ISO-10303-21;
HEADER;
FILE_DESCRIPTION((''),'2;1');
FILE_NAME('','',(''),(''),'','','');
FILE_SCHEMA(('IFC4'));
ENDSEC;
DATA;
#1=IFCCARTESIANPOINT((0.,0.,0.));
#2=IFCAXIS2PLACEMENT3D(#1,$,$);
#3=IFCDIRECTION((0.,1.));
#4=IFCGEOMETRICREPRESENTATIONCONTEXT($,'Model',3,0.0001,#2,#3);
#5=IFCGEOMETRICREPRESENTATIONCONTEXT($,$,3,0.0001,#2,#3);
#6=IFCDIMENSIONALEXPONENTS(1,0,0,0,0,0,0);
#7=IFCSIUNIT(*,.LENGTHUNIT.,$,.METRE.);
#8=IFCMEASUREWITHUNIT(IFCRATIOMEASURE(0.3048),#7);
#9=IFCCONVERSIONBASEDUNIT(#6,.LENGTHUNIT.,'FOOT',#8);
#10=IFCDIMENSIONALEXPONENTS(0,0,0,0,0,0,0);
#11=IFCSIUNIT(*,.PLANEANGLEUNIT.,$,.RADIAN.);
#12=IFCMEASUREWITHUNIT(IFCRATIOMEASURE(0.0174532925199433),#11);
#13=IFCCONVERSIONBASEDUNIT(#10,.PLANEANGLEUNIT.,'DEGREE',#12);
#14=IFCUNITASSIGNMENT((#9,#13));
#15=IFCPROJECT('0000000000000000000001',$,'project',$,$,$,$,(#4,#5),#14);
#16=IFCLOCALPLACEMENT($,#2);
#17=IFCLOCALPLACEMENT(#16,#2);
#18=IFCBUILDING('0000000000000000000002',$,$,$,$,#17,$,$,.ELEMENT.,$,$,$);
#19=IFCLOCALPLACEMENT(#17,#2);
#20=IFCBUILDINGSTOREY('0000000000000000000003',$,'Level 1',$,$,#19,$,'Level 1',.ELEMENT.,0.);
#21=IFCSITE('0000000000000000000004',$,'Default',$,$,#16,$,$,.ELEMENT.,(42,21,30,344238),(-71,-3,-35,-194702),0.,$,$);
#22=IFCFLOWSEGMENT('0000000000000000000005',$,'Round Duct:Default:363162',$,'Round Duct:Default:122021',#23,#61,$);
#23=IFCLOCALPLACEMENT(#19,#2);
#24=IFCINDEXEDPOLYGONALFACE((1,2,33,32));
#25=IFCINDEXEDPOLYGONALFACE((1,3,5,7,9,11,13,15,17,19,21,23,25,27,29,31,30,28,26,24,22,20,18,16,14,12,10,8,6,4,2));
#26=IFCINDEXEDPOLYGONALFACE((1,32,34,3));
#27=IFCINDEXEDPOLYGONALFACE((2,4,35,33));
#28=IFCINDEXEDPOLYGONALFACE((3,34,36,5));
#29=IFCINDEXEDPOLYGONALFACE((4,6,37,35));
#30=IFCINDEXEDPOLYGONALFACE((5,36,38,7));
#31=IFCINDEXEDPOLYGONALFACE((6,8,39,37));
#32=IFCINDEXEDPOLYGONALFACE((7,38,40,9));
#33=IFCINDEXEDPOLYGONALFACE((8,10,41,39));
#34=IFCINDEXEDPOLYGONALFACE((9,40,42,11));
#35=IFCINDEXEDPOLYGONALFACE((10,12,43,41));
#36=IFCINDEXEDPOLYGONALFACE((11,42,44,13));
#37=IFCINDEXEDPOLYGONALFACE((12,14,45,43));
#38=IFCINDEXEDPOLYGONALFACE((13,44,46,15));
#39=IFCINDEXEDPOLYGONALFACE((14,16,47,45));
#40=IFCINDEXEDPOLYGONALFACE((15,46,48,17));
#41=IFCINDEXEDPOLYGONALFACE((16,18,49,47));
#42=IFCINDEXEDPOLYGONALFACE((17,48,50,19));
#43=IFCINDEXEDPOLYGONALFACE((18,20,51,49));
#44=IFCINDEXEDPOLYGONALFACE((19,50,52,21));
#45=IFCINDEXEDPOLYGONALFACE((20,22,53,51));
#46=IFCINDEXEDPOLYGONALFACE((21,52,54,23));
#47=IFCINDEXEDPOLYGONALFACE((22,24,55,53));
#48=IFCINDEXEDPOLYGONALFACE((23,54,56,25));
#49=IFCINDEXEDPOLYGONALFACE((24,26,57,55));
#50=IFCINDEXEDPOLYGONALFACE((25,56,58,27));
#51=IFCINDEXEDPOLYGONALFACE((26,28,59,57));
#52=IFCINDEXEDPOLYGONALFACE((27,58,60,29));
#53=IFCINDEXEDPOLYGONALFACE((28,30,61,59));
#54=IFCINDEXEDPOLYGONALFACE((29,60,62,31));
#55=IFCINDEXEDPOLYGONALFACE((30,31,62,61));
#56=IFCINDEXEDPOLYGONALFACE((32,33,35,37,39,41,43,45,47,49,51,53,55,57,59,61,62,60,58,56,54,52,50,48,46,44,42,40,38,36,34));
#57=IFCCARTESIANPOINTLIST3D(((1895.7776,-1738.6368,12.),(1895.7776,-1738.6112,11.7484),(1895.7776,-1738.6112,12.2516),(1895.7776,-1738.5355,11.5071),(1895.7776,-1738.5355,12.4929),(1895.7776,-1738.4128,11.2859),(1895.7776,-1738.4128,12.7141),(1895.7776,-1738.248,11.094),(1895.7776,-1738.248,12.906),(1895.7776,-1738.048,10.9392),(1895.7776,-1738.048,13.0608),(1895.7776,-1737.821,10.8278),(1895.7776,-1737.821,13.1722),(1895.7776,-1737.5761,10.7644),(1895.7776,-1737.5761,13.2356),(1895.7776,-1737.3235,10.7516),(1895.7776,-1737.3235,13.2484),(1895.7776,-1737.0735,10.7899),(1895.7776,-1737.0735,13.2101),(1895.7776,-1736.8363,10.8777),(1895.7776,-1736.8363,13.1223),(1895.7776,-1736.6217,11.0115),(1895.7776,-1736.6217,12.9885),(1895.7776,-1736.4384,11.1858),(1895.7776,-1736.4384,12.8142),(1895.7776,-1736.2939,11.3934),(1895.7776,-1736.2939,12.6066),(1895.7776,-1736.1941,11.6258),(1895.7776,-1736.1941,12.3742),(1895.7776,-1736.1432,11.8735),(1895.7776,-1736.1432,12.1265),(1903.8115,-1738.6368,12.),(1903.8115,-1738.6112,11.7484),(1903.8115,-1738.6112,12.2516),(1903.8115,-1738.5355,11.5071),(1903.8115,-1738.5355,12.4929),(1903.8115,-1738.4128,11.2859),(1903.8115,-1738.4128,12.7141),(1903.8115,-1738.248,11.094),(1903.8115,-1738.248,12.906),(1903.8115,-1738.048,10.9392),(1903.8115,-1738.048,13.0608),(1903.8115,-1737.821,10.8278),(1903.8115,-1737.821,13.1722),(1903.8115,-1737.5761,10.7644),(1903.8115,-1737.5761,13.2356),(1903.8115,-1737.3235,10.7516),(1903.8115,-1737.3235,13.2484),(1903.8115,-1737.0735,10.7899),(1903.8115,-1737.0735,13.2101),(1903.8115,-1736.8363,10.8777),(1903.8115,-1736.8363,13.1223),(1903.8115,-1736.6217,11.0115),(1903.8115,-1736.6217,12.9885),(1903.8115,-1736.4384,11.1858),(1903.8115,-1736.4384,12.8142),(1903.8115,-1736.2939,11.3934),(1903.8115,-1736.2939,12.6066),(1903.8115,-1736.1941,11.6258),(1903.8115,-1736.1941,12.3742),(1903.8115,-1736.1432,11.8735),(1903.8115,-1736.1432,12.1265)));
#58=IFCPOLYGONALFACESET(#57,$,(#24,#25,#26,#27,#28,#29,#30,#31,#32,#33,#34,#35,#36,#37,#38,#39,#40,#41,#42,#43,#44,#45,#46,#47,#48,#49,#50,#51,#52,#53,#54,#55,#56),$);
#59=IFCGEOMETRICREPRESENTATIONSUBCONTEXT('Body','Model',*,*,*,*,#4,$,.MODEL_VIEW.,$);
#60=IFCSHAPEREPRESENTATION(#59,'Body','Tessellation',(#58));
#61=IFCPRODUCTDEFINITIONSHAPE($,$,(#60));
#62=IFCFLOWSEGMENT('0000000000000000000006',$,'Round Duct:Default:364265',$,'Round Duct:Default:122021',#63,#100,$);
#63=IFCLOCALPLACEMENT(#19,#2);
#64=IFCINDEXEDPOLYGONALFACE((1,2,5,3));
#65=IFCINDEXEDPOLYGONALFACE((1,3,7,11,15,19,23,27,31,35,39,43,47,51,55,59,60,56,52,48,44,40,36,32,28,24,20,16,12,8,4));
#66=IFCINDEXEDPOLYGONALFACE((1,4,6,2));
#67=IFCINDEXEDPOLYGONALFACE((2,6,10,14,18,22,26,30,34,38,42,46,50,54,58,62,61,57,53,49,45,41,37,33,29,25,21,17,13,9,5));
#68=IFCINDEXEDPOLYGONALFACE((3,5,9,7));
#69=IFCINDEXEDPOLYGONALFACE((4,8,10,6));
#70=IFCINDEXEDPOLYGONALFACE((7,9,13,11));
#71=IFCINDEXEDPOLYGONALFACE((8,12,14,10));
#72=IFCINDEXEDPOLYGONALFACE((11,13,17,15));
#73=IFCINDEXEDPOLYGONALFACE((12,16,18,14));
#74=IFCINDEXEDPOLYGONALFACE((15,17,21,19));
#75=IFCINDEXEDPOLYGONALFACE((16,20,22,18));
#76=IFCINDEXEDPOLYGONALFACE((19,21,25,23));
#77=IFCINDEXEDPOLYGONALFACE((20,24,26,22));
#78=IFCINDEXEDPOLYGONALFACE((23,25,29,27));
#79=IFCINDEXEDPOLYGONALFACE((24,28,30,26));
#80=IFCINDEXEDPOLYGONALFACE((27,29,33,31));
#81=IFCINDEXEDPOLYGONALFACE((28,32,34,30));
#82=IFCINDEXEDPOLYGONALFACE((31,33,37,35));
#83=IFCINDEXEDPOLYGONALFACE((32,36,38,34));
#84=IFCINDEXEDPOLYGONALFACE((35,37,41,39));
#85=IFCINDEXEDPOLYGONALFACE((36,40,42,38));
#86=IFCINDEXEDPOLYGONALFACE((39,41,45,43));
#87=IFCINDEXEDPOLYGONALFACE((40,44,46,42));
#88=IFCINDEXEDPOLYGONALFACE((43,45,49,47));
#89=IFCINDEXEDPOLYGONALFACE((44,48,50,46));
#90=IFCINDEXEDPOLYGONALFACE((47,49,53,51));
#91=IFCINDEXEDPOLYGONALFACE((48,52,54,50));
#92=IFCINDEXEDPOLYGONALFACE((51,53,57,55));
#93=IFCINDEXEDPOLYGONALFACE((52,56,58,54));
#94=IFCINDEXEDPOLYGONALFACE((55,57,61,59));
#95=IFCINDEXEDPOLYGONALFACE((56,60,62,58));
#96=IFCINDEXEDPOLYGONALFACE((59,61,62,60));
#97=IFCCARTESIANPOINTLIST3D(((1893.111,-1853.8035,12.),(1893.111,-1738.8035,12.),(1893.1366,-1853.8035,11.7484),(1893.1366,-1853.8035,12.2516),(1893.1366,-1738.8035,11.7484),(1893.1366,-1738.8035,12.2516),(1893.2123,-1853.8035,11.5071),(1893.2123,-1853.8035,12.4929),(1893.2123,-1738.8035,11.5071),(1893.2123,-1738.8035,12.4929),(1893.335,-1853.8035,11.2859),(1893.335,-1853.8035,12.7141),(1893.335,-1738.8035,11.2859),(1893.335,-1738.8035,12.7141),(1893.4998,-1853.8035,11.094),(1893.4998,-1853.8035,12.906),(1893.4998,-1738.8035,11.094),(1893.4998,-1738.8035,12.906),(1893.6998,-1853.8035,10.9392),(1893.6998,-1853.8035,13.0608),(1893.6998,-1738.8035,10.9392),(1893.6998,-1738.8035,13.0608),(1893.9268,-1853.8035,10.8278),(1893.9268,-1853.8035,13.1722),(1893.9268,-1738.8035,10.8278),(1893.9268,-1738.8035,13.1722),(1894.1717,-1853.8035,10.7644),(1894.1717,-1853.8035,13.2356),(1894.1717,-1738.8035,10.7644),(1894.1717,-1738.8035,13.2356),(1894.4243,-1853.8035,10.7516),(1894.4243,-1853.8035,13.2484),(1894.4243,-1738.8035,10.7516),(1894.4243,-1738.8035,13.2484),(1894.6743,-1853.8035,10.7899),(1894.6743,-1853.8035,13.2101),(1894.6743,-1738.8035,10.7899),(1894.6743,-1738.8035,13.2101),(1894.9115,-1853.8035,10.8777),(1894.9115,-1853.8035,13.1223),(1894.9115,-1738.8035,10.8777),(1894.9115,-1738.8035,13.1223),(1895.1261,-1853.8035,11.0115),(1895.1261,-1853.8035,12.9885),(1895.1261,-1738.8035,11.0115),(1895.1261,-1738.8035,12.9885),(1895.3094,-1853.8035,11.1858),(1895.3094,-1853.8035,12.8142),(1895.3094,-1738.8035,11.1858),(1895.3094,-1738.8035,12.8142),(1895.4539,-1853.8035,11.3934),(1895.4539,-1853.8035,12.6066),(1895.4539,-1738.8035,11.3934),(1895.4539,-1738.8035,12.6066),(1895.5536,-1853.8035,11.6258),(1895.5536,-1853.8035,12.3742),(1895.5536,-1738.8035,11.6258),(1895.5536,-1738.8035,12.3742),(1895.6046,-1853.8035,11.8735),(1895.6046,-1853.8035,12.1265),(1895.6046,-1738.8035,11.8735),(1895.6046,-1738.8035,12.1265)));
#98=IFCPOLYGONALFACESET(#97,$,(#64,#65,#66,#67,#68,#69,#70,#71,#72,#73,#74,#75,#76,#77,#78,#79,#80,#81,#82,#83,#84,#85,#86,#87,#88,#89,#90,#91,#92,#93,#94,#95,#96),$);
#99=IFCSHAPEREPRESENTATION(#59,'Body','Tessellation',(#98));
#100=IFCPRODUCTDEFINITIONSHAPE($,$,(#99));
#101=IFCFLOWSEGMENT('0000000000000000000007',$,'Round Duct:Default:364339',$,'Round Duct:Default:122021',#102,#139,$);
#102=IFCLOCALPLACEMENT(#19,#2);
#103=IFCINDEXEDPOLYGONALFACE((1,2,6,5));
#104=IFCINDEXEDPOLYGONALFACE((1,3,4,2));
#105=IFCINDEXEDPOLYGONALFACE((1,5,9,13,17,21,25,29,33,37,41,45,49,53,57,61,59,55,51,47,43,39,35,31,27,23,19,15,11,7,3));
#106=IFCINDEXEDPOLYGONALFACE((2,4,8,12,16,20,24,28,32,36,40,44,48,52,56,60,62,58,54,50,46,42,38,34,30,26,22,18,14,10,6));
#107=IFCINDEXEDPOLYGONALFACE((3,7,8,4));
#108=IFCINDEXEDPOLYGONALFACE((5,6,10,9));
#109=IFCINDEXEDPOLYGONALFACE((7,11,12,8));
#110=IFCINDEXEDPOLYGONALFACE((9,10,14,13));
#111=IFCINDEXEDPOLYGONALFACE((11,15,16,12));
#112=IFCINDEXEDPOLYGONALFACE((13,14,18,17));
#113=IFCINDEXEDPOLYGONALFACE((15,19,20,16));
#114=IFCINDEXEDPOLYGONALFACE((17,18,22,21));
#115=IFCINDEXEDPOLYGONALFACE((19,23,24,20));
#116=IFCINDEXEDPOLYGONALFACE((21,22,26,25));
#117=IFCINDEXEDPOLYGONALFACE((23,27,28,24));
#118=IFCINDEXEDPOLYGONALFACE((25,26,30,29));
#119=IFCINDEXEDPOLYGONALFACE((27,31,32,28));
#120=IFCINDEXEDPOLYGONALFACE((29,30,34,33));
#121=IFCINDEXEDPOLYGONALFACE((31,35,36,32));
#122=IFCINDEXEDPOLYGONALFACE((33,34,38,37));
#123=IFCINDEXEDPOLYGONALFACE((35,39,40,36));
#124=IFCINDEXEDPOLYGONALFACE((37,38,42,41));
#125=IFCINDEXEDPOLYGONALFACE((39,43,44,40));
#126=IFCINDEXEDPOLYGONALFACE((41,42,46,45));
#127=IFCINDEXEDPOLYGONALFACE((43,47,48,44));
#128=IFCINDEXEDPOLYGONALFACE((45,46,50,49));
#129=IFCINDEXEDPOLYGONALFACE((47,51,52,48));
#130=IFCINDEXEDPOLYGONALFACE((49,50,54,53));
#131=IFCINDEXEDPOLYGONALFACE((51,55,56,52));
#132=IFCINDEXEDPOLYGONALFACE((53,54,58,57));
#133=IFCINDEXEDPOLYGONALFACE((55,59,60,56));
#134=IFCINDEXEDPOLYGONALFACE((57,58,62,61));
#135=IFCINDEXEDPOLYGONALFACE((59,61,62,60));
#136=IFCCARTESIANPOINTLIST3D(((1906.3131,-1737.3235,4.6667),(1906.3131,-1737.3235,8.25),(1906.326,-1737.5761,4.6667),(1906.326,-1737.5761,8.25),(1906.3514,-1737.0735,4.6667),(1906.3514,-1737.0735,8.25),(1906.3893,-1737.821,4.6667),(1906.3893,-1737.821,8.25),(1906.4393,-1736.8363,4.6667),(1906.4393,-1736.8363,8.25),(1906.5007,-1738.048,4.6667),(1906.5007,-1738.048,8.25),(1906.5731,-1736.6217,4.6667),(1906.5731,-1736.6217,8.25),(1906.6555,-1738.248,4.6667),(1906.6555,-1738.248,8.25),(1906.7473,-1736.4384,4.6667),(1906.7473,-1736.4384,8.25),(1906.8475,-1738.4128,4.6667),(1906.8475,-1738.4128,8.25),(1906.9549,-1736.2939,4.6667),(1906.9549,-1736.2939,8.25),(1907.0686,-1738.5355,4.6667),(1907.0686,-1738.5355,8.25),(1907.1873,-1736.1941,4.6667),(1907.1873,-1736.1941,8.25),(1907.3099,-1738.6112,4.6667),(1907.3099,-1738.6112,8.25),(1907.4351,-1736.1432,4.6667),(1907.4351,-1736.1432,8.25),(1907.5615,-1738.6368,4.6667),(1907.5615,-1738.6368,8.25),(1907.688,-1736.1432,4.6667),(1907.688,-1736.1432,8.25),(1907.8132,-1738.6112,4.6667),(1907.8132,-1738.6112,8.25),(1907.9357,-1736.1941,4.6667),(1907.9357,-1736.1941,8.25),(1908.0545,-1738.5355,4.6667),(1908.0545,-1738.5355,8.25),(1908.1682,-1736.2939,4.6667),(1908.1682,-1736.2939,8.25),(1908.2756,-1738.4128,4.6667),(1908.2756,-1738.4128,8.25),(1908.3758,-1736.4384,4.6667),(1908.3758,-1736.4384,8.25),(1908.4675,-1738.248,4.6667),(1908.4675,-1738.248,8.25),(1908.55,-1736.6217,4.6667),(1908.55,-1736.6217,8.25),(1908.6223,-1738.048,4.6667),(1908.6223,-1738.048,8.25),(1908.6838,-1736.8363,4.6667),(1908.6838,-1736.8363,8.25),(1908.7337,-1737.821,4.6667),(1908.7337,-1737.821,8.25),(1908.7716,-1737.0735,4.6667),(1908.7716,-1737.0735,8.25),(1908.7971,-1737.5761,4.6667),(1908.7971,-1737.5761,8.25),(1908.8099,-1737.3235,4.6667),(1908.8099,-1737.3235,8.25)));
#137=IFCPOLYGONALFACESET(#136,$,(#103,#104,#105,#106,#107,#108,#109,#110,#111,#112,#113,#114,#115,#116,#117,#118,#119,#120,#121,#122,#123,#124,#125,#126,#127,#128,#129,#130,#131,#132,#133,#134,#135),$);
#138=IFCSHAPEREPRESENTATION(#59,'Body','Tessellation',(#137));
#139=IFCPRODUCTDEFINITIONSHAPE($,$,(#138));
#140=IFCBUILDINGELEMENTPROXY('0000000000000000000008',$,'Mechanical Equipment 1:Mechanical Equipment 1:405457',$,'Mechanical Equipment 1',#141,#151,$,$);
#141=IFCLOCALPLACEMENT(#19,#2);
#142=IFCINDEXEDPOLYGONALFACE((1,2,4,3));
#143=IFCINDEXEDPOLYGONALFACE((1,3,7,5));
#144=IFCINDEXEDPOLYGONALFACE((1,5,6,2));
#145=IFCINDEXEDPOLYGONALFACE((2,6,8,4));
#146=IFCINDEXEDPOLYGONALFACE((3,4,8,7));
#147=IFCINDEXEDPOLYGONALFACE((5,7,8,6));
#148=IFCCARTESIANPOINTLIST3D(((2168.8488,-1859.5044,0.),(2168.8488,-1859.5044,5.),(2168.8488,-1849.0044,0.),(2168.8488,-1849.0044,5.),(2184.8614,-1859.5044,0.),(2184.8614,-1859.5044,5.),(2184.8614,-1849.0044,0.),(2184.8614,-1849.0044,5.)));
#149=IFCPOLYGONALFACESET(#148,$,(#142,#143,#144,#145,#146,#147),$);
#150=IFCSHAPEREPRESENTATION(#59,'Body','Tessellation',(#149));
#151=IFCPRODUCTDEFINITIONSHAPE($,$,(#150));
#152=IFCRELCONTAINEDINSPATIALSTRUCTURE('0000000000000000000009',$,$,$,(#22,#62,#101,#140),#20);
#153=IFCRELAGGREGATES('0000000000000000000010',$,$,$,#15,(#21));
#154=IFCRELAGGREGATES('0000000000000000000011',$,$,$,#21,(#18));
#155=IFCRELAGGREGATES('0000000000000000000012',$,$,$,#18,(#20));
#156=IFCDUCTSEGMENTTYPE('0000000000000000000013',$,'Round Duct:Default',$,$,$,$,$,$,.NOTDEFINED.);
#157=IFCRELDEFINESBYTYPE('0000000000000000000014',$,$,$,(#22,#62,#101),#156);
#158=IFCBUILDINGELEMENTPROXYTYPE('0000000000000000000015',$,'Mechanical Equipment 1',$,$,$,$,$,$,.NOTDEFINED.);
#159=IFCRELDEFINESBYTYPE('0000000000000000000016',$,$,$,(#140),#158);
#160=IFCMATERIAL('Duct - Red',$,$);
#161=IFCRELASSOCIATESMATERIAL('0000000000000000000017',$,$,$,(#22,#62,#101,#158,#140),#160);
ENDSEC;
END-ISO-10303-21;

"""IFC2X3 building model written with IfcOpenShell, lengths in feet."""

from ifc_helpers import new_model, entity, si_unit, converted_unit, direction, frame, frame_2d, origin, origin_2d_with_axis, place, context, subcontext, project, spatial, rectangle, circle, extrude, source, transform, mapped, material, type_object, type_shapes, element, save


model = new_model("IFC2X3")

# Units and contexts
model_context = context("Model", 3, precision=0.0001, world=origin(), true_north=direction((0.0, 1.0)))
context_of_model = context(None, 3, precision=0.0001, world=origin(), true_north=direction((0.0, 1.0)))
body_context = subcontext(model_context, "Body", "Model", "MODEL_VIEW")
ifc_project = project(units=[converted_unit("LENGTHUNIT", "FOOT", entity("IfcRatioMeasure", 0.3048), si_unit("LENGTHUNIT", "METRE"), dimensions=[1, 0, 0, 0, 0, 0, 0]), converted_unit("PLANEANGLEUNIT", "DEGREE", entity("IfcRatioMeasure", 0.0174532925199433), si_unit("PLANEANGLEUNIT", "RADIAN"), dimensions=[0, 0, 0, 0, 0, 0, 0])], contexts=[model_context, context_of_model])

# Site, building, storey
site_placement = place(None, origin())
site = spatial("IfcSite", under=ifc_project, at=site_placement, Name="Default", CompositionType="ELEMENT", RefLatitude=(42, 21, 30, 344238), RefLongitude=(-71, -3, -35, -194702), RefElevation=0.0)
building_placement = place(site_placement, origin())
building = spatial("IfcBuilding", under=site, at=building_placement, CompositionType="ELEMENT")
storey_placement = place(building_placement, origin())
storey = spatial("IfcBuildingStorey", under=building, at=storey_placement, Name="Level 1", LongName="Level 1", CompositionType="ELEMENT", Elevation=0.0)

# Flow segments
ifc_material_1 = material(Name="Duct - Red")
duct_segment_type = type_object("IfcDuctSegmentType", Name="Round Duct:Default", PredefinedType="NOTDEFINED")
flow_segment_1_placement = place(storey_placement, origin())
element("IfcFlowSegment", 1, at=flow_segment_1_placement, inside=storey, type_object=duct_segment_type, material=ifc_material_1, Name="Round Duct:Default:363162", ObjectType="Round Duct:Default:122021", context=body_context, shape_type="SweptSolid", body=[
    extrude(circle(Radius=1.25, at=origin_2d_with_axis()), frame((1895.7776, -1737.3868, 12.0), z_axis=(1.0, 0.0, 0.0), x_axis=(0.0, -1.0, 0.0)), (0.0, 0.0, 1.0), 8.0339),
])
flow_segment_2_placement = place(storey_placement, origin())
element("IfcFlowSegment", 2, at=flow_segment_2_placement, inside=storey, type_object=duct_segment_type, material=ifc_material_1, Name="Round Duct:Default:364265", ObjectType="Round Duct:Default:122021", context=body_context, shape_type="SweptSolid", body=[
    extrude(circle(Radius=1.25, at=frame_2d((0.0, 0.0), x_axis=(1.0, 0.0))), frame((1894.361, -1853.8035, 12.0), z_axis=(0.0, 1.0, 0.0), x_axis=(-1.0, 0.0, 0.0)), (0.0, 0.0, 1.0), 115.0),
])
flow_segment_3_placement = place(storey_placement, origin())
element("IfcFlowSegment", 3, at=flow_segment_3_placement, inside=storey, type_object=duct_segment_type, material=ifc_material_1, Name="Round Duct:Default:364339", ObjectType="Round Duct:Default:122021", context=body_context, shape_type="SweptSolid", body=[
    extrude(circle(Radius=1.25, at=origin_2d_with_axis()), frame((1907.5615, -1737.3868, 4.6667), z_axis=(0.0, 0.0, 1.0), x_axis=(0.0, -1.0, 0.0)), (0.0, 0.0, 1.0), 3.5833),
])

# Building element proxy
building_element_proxy_type_1 = type_object("IfcBuildingElementProxyType", Name="Mechanical Equipment 1", PredefinedType="NOTDEFINED", material=ifc_material_1)
shared_shape_1 = source(origin(), body_context, "Body", "SweptSolid", [
    extrude(rectangle(XDim=16.0126, YDim=10.5, at=origin_2d_with_axis()), frame((2176.8551, -1854.2544, 0.0), z_axis=(0.0, 0.0, 1.0), x_axis=(-1.0, 0.0, 0.0)), (0.0, 0.0, 1.0), 5.0),
])
type_shapes(building_element_proxy_type_1, [shared_shape_1])
proxy_1_placement = place(storey_placement, origin())
element("IfcBuildingElementProxy", 4, at=proxy_1_placement, inside=storey, type_object=building_element_proxy_type_1, material=ifc_material_1, Name="Mechanical Equipment 1:Mechanical Equipment 1:405457", ObjectType="Mechanical Equipment 1", context=body_context, shape_type="MappedRepresentation", body=[
    mapped(shared_shape_1, transform((0.0, 0.0, 0.0), scale=1.0)),
])

save(model, "model.ifc")
